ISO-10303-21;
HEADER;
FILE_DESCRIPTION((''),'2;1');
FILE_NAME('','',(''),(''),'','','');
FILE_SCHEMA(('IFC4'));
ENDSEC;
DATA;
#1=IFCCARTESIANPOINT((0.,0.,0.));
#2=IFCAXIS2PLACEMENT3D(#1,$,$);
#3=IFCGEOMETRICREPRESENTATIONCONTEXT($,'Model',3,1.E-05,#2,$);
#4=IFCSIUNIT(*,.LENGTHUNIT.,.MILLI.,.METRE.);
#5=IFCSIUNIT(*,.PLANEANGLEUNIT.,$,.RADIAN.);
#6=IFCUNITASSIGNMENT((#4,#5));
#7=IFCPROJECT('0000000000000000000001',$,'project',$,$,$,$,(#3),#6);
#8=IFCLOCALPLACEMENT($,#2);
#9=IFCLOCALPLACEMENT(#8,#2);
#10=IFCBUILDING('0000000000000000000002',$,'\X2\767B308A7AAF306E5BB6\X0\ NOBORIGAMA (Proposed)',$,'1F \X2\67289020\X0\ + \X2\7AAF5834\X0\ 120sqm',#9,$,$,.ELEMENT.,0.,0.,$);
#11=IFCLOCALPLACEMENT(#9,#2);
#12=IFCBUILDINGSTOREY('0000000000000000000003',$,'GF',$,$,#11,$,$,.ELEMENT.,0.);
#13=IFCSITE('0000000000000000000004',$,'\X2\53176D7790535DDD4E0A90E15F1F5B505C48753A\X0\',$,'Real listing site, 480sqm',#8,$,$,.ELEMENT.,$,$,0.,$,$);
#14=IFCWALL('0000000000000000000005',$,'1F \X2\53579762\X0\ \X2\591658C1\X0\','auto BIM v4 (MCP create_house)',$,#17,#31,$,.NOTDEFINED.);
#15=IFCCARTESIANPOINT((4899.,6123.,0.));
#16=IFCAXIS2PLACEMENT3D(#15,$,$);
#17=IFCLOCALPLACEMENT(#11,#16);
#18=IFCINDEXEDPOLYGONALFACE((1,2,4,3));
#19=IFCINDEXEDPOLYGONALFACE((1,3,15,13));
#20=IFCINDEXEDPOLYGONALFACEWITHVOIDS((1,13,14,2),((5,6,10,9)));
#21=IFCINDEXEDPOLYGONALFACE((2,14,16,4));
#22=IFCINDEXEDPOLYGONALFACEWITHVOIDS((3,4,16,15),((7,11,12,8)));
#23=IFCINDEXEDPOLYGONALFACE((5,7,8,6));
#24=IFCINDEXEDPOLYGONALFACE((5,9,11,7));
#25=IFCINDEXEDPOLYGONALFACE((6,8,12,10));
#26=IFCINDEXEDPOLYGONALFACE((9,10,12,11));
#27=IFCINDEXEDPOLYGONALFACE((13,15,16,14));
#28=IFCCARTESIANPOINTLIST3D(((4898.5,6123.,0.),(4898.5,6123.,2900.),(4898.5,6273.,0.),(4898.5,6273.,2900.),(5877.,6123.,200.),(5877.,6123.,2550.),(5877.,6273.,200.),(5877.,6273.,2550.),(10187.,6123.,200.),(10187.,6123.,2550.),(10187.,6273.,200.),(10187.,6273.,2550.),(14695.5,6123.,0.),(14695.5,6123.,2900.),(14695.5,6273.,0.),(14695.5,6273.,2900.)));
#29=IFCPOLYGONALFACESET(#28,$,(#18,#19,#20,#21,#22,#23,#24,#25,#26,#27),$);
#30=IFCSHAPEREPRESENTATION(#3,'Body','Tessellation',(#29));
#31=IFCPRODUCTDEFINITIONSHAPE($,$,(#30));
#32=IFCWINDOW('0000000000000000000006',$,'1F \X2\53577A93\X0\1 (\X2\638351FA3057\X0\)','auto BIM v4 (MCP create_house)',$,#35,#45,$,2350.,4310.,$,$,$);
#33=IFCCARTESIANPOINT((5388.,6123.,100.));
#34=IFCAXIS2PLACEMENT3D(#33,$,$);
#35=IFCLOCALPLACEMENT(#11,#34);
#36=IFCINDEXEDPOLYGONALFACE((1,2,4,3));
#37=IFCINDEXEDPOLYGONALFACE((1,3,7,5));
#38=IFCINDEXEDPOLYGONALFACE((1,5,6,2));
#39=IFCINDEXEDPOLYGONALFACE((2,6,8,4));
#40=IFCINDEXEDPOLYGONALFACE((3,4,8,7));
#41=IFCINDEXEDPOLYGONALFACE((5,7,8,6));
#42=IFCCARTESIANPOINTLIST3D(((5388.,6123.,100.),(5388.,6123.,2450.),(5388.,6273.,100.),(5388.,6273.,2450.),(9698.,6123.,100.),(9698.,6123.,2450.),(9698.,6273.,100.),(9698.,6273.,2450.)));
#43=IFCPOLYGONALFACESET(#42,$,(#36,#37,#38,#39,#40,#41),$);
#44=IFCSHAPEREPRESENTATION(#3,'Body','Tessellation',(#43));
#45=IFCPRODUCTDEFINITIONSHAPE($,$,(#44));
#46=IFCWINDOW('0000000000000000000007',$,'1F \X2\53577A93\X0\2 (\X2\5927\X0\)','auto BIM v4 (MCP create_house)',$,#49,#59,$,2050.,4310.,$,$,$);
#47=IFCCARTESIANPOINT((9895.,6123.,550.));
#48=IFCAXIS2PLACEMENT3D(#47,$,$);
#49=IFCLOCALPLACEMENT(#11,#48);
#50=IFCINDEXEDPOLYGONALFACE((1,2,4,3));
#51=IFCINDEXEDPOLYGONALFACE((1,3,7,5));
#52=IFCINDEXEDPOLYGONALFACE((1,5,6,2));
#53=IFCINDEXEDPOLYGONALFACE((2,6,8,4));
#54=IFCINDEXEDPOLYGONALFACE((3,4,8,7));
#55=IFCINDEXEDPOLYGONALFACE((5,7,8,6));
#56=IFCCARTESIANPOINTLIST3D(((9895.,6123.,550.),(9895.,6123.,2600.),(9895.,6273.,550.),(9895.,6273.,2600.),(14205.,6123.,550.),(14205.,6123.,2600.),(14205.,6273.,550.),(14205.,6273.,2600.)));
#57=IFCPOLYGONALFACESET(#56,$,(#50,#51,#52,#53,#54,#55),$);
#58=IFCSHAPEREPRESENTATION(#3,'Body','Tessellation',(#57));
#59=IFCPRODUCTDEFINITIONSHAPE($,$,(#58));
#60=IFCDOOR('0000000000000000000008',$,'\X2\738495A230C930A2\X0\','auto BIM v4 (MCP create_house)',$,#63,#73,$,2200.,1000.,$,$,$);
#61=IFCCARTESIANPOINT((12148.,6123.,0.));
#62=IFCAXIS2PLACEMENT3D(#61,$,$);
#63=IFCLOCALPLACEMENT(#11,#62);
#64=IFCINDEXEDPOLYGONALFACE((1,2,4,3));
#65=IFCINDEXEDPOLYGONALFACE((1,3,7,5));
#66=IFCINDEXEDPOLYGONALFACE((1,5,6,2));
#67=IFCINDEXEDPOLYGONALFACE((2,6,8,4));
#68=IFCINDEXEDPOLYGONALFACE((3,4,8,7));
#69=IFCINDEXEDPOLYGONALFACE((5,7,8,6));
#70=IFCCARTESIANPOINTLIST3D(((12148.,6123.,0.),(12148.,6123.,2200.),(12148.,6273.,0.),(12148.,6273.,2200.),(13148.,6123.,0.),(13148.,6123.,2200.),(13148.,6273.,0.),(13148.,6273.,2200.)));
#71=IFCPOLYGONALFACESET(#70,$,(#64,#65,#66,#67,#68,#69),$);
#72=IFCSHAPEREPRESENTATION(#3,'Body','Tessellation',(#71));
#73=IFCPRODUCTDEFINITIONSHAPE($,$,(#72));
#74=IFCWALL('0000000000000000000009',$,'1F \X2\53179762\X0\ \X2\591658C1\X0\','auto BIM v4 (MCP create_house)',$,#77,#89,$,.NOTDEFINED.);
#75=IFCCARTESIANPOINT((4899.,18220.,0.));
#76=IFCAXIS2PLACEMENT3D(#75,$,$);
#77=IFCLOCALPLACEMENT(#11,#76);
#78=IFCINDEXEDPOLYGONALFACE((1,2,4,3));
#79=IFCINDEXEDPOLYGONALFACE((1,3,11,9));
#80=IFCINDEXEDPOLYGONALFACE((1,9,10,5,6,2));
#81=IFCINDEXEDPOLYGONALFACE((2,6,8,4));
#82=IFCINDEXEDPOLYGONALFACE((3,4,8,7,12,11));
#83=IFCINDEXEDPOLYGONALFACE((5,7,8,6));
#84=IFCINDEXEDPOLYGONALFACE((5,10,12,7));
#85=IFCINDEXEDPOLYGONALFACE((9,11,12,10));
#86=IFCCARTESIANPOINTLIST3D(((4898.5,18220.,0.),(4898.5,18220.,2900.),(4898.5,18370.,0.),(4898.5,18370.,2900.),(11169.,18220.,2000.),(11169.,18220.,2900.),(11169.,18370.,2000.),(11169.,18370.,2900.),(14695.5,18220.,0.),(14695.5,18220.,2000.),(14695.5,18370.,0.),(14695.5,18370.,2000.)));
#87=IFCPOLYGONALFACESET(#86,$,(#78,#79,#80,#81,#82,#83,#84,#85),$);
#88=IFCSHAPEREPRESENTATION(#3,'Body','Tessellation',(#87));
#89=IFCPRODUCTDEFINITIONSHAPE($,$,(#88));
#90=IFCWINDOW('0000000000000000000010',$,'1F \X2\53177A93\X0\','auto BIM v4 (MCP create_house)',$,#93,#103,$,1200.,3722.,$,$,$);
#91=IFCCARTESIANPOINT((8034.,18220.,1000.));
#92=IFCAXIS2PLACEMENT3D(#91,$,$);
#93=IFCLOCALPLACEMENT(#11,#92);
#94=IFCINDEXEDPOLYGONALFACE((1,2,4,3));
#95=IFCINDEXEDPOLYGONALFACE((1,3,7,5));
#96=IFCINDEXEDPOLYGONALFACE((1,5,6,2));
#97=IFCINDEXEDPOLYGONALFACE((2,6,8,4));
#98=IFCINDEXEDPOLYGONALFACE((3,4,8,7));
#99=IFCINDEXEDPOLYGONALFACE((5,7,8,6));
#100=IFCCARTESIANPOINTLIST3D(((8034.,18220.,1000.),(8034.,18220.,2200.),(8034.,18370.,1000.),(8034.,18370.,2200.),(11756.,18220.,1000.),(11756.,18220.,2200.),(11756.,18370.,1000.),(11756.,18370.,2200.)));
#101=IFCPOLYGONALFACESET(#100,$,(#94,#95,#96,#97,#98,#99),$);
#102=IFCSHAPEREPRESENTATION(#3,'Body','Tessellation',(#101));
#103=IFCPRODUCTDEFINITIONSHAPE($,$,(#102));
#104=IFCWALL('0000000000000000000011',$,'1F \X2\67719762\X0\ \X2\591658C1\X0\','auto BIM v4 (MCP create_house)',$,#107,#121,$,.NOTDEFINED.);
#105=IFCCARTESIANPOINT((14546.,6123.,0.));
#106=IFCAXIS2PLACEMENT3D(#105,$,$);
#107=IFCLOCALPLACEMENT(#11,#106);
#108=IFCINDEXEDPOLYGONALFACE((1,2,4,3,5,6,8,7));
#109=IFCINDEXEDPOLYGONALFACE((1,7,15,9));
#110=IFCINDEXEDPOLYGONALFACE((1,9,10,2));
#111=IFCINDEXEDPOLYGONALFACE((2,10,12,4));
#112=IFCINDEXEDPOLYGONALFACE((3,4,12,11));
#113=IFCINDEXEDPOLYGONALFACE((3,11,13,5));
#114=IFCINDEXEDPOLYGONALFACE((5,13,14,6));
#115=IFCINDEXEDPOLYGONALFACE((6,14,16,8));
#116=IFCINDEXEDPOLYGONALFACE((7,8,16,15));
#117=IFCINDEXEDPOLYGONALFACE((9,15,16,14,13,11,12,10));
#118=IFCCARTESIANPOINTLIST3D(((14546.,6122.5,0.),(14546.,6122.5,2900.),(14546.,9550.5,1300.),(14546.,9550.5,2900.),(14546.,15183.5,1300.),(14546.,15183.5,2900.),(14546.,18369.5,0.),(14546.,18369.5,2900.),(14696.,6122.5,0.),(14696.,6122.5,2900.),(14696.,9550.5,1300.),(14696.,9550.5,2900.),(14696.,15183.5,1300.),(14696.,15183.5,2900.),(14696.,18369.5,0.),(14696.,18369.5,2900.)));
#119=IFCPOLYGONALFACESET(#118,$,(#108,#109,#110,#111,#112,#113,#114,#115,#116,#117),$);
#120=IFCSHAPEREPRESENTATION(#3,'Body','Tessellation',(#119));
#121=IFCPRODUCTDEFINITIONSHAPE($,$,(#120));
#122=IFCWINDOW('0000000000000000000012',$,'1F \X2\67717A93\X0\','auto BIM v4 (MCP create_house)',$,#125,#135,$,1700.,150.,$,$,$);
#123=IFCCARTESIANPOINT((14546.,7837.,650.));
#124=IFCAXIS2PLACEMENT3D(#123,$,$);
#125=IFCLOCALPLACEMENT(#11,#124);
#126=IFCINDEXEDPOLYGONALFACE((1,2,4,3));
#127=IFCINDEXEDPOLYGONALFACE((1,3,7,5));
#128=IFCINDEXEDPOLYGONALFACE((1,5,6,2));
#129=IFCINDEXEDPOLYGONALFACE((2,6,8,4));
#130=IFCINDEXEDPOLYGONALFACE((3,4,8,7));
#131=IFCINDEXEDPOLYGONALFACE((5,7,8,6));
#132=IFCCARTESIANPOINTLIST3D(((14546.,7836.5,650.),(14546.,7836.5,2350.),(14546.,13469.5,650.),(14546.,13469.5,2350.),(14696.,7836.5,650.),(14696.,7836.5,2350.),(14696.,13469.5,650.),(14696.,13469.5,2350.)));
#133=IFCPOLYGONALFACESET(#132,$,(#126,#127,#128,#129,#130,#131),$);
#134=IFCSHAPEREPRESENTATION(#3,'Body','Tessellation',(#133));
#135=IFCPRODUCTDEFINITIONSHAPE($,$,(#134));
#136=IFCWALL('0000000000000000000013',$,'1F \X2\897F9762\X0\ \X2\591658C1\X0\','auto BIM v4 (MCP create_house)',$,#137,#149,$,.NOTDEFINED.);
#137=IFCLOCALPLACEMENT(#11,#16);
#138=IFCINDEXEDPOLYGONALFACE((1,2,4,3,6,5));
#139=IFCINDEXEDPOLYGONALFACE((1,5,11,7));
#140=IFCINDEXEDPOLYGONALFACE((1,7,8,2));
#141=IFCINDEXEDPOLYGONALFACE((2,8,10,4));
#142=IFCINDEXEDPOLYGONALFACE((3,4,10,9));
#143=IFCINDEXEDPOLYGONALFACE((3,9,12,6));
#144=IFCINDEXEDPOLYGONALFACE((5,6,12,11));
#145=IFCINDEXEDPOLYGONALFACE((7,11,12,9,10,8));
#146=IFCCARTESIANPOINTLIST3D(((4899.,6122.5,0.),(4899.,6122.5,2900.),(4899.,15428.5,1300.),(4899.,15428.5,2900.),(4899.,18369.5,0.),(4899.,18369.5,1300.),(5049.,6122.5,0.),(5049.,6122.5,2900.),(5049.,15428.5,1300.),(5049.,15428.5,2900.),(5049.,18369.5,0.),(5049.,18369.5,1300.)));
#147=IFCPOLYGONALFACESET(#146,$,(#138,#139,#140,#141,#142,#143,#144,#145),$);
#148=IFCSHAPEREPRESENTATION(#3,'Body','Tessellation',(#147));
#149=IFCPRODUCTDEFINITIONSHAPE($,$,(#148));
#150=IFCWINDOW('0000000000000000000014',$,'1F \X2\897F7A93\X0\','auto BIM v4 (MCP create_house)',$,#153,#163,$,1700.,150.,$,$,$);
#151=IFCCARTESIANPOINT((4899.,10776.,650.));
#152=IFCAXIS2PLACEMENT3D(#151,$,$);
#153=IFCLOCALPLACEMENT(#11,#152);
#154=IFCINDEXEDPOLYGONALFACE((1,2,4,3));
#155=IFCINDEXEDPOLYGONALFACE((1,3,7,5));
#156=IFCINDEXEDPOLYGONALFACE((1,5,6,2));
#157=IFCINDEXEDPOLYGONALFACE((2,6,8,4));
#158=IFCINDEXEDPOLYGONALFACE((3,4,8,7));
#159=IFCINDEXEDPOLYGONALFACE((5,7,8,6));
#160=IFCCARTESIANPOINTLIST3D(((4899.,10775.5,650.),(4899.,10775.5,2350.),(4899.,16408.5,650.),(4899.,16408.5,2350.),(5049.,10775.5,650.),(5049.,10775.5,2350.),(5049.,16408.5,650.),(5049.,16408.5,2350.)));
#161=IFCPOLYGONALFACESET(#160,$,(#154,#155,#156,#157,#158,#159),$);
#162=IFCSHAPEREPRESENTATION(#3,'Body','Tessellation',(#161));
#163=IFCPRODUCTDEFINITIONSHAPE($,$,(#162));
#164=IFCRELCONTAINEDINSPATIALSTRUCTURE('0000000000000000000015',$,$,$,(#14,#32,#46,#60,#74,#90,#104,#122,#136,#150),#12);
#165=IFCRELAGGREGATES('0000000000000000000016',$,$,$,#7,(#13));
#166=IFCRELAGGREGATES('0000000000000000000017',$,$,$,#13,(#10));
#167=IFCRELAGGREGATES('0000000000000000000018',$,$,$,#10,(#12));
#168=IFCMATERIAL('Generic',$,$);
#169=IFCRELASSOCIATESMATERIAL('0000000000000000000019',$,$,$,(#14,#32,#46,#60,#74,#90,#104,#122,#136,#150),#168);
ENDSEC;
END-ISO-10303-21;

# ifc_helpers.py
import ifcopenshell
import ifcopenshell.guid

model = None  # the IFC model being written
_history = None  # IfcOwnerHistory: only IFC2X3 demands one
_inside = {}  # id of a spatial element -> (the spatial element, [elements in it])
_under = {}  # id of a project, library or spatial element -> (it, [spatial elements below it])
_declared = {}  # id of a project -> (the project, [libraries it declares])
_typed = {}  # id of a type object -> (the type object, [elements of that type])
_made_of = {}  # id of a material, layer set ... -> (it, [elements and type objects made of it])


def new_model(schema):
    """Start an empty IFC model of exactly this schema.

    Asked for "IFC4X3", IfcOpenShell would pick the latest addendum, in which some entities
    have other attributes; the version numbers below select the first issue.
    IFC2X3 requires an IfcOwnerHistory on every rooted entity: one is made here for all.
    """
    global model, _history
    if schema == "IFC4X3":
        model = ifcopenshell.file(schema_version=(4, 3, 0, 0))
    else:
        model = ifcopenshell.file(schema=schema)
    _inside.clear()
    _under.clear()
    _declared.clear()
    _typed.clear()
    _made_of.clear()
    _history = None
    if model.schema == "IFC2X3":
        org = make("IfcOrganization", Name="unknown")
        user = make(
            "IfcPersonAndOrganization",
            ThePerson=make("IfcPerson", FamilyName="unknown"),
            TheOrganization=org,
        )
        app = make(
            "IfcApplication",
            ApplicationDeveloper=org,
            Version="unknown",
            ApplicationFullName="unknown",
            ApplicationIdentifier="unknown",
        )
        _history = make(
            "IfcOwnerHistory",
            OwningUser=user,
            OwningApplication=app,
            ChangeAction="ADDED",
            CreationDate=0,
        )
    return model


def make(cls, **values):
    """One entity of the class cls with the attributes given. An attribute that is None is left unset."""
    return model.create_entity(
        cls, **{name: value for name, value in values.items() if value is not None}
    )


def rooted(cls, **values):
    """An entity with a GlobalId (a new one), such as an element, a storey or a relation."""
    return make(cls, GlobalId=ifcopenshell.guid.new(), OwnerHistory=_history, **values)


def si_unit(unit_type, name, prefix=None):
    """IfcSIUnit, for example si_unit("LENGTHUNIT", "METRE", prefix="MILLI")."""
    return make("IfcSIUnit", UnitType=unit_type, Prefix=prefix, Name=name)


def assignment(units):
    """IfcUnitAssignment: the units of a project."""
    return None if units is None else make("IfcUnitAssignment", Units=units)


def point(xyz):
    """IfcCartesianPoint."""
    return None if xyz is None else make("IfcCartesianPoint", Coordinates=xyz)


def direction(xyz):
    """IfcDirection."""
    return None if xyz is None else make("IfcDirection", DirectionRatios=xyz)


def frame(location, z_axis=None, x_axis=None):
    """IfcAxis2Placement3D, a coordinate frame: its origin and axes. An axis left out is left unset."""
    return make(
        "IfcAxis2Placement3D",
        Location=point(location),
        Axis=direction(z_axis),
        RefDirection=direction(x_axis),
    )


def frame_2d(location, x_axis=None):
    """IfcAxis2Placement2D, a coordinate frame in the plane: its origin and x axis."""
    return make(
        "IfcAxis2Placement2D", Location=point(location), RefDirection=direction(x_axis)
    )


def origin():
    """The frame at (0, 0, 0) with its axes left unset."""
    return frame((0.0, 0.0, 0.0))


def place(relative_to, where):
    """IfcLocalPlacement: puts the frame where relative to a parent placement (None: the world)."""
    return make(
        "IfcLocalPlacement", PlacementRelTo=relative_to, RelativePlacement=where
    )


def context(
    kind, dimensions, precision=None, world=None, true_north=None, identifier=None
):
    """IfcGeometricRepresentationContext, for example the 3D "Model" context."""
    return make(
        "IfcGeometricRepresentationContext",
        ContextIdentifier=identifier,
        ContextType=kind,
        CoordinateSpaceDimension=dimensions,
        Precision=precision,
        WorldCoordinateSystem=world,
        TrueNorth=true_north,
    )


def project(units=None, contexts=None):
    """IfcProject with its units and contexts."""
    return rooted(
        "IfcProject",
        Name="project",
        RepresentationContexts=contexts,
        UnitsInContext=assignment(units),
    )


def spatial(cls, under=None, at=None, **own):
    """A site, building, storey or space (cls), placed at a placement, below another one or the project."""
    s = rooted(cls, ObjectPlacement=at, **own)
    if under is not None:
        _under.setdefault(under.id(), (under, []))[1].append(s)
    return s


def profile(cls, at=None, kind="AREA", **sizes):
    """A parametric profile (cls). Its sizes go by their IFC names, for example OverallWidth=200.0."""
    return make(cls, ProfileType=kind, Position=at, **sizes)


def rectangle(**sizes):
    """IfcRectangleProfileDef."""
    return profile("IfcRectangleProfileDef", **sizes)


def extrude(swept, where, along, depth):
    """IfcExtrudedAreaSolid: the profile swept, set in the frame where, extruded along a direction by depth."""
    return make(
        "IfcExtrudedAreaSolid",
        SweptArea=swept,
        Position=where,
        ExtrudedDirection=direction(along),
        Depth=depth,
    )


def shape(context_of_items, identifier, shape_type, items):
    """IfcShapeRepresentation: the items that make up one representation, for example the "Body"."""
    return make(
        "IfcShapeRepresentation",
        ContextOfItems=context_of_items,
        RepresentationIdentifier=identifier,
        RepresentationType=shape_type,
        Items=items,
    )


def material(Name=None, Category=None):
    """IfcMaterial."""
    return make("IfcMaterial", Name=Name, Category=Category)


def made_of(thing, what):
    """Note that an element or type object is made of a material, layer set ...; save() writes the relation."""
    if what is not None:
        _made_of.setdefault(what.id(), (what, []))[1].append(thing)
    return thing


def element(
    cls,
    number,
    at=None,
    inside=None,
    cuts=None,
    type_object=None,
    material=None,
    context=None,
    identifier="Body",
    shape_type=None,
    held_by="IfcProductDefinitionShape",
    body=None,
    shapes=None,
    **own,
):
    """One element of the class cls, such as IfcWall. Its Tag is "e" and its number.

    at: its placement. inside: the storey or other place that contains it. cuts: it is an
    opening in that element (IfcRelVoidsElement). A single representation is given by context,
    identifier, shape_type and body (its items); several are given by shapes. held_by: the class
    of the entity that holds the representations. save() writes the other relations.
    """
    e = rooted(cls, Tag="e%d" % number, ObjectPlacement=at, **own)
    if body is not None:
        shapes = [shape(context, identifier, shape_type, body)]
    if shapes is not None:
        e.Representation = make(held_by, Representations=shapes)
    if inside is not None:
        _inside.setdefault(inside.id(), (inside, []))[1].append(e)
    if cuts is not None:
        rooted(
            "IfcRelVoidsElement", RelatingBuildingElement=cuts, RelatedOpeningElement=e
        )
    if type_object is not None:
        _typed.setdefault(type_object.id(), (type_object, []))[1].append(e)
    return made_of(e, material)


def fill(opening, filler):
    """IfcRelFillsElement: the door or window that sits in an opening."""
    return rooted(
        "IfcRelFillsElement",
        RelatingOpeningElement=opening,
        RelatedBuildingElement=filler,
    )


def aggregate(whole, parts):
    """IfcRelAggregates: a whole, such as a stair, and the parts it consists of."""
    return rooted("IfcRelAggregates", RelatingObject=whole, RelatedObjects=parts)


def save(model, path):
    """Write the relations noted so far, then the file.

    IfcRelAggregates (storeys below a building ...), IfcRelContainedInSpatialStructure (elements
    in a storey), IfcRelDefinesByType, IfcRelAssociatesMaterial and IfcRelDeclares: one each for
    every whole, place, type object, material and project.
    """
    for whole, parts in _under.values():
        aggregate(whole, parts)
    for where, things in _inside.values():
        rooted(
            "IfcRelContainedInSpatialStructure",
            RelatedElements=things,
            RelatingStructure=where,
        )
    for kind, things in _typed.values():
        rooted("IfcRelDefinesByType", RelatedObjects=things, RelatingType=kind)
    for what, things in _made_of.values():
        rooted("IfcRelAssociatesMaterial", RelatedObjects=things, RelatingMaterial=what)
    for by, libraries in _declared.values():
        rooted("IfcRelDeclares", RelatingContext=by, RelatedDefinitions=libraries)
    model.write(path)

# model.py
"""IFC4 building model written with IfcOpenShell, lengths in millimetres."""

from ifc_helpers import new_model, si_unit, frame, frame_2d, origin, place, context, project, spatial, rectangle, extrude, material, element, fill, save


model = new_model("IFC4")

# Units and contexts
model_context = context("Model", 3, precision=1e-05, world=origin())
ifc_project = project(units=[si_unit("LENGTHUNIT", "METRE", prefix="MILLI"), si_unit("PLANEANGLEUNIT", "RADIAN")], contexts=[model_context])

# Site, building, storey
site_placement = place(None, origin())
site = spatial("IfcSite", under=ifc_project, at=site_placement, Name="北海道川上郡弟子屈町", ObjectType="Real listing site, 480sqm", CompositionType="ELEMENT", RefElevation=0.0)
building_placement = place(site_placement, origin())
building = spatial("IfcBuilding", under=site, at=building_placement, Name="登り窯の家 NOBORIGAMA (Proposed)", ObjectType="1F 木造 + 窯場 120sqm", CompositionType="ELEMENT", ElevationOfRefHeight=0.0, ElevationOfTerrain=0.0)
storey_placement = place(building_placement, origin())
storey = spatial("IfcBuildingStorey", under=building, at=storey_placement, Name="GF", CompositionType="ELEMENT", Elevation=0.0)

# Shared definitions
ifc_material = material(Name="Generic")

# Wall, openings, windows, door
wall_1_placement = place(storey_placement, frame((4899.0, 6123.0, 0.0)))
wall_1 = element("IfcWall", 1, at=wall_1_placement, inside=storey, material=ifc_material, Name="1F 南面 外壁", Description="auto BIM v4 (MCP create_house)", PredefinedType="NOTDEFINED", context=model_context, shape_type="SweptSolid", body=[
    extrude(rectangle(XDim=9797.0, YDim=150.0, at=frame_2d((4898.0, 75.0))), frame((4899.0, 6123.0, 0.0)), (0.0, 0.0, 1.0), 2900.0),
])
opening_1_placement = place(storey_placement, frame((5388.0, 6123.0, 100.0)))
opening_1 = element("IfcOpeningElement", 2, at=opening_1_placement, cuts=wall_1, PredefinedType="NOTDEFINED", context=model_context, shape_type="SweptSolid", body=[
    extrude(rectangle(XDim=4310.0, YDim=150.0, at=frame_2d((2155.0, 75.0))), frame((5388.0, 6123.0, 100.0)), (0.0, 0.0, 1.0), 2350.0),
])
opening_2_placement = place(storey_placement, frame((9895.0, 6123.0, 550.0)))
opening_2 = element("IfcOpeningElement", 3, at=opening_2_placement, cuts=wall_1, PredefinedType="NOTDEFINED", context=model_context, shape_type="SweptSolid", body=[
    extrude(rectangle(XDim=4310.0, YDim=150.0, at=frame_2d((2155.0, 75.0))), frame((9895.0, 6123.0, 550.0)), (0.0, 0.0, 1.0), 2050.0),
])
opening_3_placement = place(storey_placement, frame((12148.0, 6123.0, 0.0)))
opening_3 = element("IfcOpeningElement", 4, at=opening_3_placement, cuts=wall_1, PredefinedType="NOTDEFINED", context=model_context, shape_type="SweptSolid", body=[
    extrude(rectangle(XDim=1000.0, YDim=150.0, at=frame_2d((500.0, 75.0))), frame((12148.0, 6123.0, 0.0)), (0.0, 0.0, 1.0), 2200.0),
])
window_1_placement = place(storey_placement, frame((5388.0, 6123.0, 100.0)))
window_1 = element("IfcWindow", 5, at=window_1_placement, inside=storey, material=ifc_material, Name="1F 南窓1 (掃出し)", Description="auto BIM v4 (MCP create_house)", OverallHeight=2350.0, OverallWidth=4310.0, context=model_context, shape_type="SweptSolid", body=[
    extrude(rectangle(XDim=4310.0, YDim=150.0, at=frame_2d((2155.0, 75.0))), frame((5388.0, 6123.0, 100.0)), (0.0, 0.0, 1.0), 2350.0),
])
fill(opening_1, window_1)
window_2_placement = place(storey_placement, frame((9895.0, 6123.0, 550.0)))
window_2 = element("IfcWindow", 6, at=window_2_placement, inside=storey, material=ifc_material, Name="1F 南窓2 (大)", Description="auto BIM v4 (MCP create_house)", OverallHeight=2050.0, OverallWidth=4310.0, context=model_context, shape_type="SweptSolid", body=[
    extrude(rectangle(XDim=4310.0, YDim=150.0, at=frame_2d((2155.0, 75.0))), frame((9895.0, 6123.0, 550.0)), (0.0, 0.0, 1.0), 2050.0),
])
fill(opening_2, window_2)
door_placement = place(storey_placement, frame((12148.0, 6123.0, 0.0)))
door = element("IfcDoor", 7, at=door_placement, inside=storey, material=ifc_material, Name="玄関ドア", Description="auto BIM v4 (MCP create_house)", OverallHeight=2200.0, OverallWidth=1000.0, context=model_context, shape_type="SweptSolid", body=[
    extrude(rectangle(XDim=1000.0, YDim=150.0, at=frame_2d((500.0, 75.0))), frame((12148.0, 6123.0, 0.0)), (0.0, 0.0, 1.0), 2200.0),
])
fill(opening_3, door)

# Walls, openings, windows
wall_2_placement = place(storey_placement, frame((4899.0, 18220.0, 0.0)))
wall_2 = element("IfcWall", 8, at=wall_2_placement, inside=storey, material=ifc_material, Name="1F 北面 外壁", Description="auto BIM v4 (MCP create_house)", PredefinedType="NOTDEFINED", context=model_context, shape_type="SweptSolid", body=[
    extrude(rectangle(XDim=9797.0, YDim=150.0, at=frame_2d((4898.0, 75.0))), frame((4899.0, 18220.0, 0.0)), (0.0, 0.0, 1.0), 2900.0),
])
opening_4_placement = place(storey_placement, frame((8034.0, 18220.0, 1000.0)))
opening_4 = element("IfcOpeningElement", 9, at=opening_4_placement, cuts=wall_2, PredefinedType="NOTDEFINED", context=model_context, shape_type="SweptSolid", body=[
    extrude(rectangle(XDim=3722.0, YDim=150.0, at=frame_2d((1861.0, 75.0))), frame((8034.0, 18220.0, 1000.0)), (0.0, 0.0, 1.0), 1200.0),
])
window_3_placement = place(storey_placement, frame((8034.0, 18220.0, 1000.0)))
window_3 = element("IfcWindow", 10, at=window_3_placement, inside=storey, material=ifc_material, Name="1F 北窓", Description="auto BIM v4 (MCP create_house)", OverallHeight=1200.0, OverallWidth=3722.0, context=model_context, shape_type="SweptSolid", body=[
    extrude(rectangle(XDim=3722.0, YDim=150.0, at=frame_2d((1861.0, 75.0))), frame((8034.0, 18220.0, 1000.0)), (0.0, 0.0, 1.0), 1200.0),
])
fill(opening_4, window_3)
wall_3_placement = place(storey_placement, frame((14546.0, 6123.0, 0.0)))
wall_3 = element("IfcWall", 11, at=wall_3_placement, inside=storey, material=ifc_material, Name="1F 東面 外壁", Description="auto BIM v4 (MCP create_house)", PredefinedType="NOTDEFINED", context=model_context, shape_type="SweptSolid", body=[
    extrude(rectangle(XDim=150.0, YDim=12247.0, at=frame_2d((75.0, 6123.0))), frame((14546.0, 6123.0, 0.0)), (0.0, 0.0, 1.0), 2900.0),
])
opening_5_placement = place(storey_placement, frame((14546.0, 7837.0, 650.0)))
opening_5 = element("IfcOpeningElement", 12, at=opening_5_placement, cuts=wall_3, PredefinedType="NOTDEFINED", context=model_context, shape_type="SweptSolid", body=[
    extrude(rectangle(XDim=150.0, YDim=5633.0, at=frame_2d((75.0, 2816.0))), frame((14546.0, 7837.0, 650.0)), (0.0, 0.0, 1.0), 1700.0),
])
window_4_placement = place(storey_placement, frame((14546.0, 7837.0, 650.0)))
window_4 = element("IfcWindow", 13, at=window_4_placement, inside=storey, material=ifc_material, Name="1F 東窓", Description="auto BIM v4 (MCP create_house)", OverallHeight=1700.0, OverallWidth=150.0, context=model_context, shape_type="SweptSolid", body=[
    extrude(rectangle(XDim=150.0, YDim=5633.0, at=frame_2d((75.0, 2816.0))), frame((14546.0, 7837.0, 650.0)), (0.0, 0.0, 1.0), 1700.0),
])
fill(opening_5, window_4)
wall_4_placement = place(storey_placement, frame((4899.0, 6123.0, 0.0)))
wall_4 = element("IfcWall", 14, at=wall_4_placement, inside=storey, material=ifc_material, Name="1F 西面 外壁", Description="auto BIM v4 (MCP create_house)", PredefinedType="NOTDEFINED", context=model_context, shape_type="SweptSolid", body=[
    extrude(rectangle(XDim=150.0, YDim=12247.0, at=frame_2d((75.0, 6123.0))), frame((4899.0, 6123.0, 0.0)), (0.0, 0.0, 1.0), 2900.0),
])
opening_6_placement = place(storey_placement, frame((4899.0, 10776.0, 650.0)))
opening_6 = element("IfcOpeningElement", 15, at=opening_6_placement, cuts=wall_4, PredefinedType="NOTDEFINED", context=model_context, shape_type="SweptSolid", body=[
    extrude(rectangle(XDim=150.0, YDim=5633.0, at=frame_2d((75.0, 2816.0))), frame((4899.0, 10776.0, 650.0)), (0.0, 0.0, 1.0), 1700.0),
])
window_5_placement = place(storey_placement, frame((4899.0, 10776.0, 650.0)))
window_5 = element("IfcWindow", 16, at=window_5_placement, inside=storey, material=ifc_material, Name="1F 西窓", Description="auto BIM v4 (MCP create_house)", OverallHeight=1700.0, OverallWidth=150.0, context=model_context, shape_type="SweptSolid", body=[
    extrude(rectangle(XDim=150.0, YDim=5633.0, at=frame_2d((75.0, 2816.0))), frame((4899.0, 10776.0, 650.0)), (0.0, 0.0, 1.0), 1700.0),
])
fill(opening_6, window_5)

save(model, "model.ifc")
